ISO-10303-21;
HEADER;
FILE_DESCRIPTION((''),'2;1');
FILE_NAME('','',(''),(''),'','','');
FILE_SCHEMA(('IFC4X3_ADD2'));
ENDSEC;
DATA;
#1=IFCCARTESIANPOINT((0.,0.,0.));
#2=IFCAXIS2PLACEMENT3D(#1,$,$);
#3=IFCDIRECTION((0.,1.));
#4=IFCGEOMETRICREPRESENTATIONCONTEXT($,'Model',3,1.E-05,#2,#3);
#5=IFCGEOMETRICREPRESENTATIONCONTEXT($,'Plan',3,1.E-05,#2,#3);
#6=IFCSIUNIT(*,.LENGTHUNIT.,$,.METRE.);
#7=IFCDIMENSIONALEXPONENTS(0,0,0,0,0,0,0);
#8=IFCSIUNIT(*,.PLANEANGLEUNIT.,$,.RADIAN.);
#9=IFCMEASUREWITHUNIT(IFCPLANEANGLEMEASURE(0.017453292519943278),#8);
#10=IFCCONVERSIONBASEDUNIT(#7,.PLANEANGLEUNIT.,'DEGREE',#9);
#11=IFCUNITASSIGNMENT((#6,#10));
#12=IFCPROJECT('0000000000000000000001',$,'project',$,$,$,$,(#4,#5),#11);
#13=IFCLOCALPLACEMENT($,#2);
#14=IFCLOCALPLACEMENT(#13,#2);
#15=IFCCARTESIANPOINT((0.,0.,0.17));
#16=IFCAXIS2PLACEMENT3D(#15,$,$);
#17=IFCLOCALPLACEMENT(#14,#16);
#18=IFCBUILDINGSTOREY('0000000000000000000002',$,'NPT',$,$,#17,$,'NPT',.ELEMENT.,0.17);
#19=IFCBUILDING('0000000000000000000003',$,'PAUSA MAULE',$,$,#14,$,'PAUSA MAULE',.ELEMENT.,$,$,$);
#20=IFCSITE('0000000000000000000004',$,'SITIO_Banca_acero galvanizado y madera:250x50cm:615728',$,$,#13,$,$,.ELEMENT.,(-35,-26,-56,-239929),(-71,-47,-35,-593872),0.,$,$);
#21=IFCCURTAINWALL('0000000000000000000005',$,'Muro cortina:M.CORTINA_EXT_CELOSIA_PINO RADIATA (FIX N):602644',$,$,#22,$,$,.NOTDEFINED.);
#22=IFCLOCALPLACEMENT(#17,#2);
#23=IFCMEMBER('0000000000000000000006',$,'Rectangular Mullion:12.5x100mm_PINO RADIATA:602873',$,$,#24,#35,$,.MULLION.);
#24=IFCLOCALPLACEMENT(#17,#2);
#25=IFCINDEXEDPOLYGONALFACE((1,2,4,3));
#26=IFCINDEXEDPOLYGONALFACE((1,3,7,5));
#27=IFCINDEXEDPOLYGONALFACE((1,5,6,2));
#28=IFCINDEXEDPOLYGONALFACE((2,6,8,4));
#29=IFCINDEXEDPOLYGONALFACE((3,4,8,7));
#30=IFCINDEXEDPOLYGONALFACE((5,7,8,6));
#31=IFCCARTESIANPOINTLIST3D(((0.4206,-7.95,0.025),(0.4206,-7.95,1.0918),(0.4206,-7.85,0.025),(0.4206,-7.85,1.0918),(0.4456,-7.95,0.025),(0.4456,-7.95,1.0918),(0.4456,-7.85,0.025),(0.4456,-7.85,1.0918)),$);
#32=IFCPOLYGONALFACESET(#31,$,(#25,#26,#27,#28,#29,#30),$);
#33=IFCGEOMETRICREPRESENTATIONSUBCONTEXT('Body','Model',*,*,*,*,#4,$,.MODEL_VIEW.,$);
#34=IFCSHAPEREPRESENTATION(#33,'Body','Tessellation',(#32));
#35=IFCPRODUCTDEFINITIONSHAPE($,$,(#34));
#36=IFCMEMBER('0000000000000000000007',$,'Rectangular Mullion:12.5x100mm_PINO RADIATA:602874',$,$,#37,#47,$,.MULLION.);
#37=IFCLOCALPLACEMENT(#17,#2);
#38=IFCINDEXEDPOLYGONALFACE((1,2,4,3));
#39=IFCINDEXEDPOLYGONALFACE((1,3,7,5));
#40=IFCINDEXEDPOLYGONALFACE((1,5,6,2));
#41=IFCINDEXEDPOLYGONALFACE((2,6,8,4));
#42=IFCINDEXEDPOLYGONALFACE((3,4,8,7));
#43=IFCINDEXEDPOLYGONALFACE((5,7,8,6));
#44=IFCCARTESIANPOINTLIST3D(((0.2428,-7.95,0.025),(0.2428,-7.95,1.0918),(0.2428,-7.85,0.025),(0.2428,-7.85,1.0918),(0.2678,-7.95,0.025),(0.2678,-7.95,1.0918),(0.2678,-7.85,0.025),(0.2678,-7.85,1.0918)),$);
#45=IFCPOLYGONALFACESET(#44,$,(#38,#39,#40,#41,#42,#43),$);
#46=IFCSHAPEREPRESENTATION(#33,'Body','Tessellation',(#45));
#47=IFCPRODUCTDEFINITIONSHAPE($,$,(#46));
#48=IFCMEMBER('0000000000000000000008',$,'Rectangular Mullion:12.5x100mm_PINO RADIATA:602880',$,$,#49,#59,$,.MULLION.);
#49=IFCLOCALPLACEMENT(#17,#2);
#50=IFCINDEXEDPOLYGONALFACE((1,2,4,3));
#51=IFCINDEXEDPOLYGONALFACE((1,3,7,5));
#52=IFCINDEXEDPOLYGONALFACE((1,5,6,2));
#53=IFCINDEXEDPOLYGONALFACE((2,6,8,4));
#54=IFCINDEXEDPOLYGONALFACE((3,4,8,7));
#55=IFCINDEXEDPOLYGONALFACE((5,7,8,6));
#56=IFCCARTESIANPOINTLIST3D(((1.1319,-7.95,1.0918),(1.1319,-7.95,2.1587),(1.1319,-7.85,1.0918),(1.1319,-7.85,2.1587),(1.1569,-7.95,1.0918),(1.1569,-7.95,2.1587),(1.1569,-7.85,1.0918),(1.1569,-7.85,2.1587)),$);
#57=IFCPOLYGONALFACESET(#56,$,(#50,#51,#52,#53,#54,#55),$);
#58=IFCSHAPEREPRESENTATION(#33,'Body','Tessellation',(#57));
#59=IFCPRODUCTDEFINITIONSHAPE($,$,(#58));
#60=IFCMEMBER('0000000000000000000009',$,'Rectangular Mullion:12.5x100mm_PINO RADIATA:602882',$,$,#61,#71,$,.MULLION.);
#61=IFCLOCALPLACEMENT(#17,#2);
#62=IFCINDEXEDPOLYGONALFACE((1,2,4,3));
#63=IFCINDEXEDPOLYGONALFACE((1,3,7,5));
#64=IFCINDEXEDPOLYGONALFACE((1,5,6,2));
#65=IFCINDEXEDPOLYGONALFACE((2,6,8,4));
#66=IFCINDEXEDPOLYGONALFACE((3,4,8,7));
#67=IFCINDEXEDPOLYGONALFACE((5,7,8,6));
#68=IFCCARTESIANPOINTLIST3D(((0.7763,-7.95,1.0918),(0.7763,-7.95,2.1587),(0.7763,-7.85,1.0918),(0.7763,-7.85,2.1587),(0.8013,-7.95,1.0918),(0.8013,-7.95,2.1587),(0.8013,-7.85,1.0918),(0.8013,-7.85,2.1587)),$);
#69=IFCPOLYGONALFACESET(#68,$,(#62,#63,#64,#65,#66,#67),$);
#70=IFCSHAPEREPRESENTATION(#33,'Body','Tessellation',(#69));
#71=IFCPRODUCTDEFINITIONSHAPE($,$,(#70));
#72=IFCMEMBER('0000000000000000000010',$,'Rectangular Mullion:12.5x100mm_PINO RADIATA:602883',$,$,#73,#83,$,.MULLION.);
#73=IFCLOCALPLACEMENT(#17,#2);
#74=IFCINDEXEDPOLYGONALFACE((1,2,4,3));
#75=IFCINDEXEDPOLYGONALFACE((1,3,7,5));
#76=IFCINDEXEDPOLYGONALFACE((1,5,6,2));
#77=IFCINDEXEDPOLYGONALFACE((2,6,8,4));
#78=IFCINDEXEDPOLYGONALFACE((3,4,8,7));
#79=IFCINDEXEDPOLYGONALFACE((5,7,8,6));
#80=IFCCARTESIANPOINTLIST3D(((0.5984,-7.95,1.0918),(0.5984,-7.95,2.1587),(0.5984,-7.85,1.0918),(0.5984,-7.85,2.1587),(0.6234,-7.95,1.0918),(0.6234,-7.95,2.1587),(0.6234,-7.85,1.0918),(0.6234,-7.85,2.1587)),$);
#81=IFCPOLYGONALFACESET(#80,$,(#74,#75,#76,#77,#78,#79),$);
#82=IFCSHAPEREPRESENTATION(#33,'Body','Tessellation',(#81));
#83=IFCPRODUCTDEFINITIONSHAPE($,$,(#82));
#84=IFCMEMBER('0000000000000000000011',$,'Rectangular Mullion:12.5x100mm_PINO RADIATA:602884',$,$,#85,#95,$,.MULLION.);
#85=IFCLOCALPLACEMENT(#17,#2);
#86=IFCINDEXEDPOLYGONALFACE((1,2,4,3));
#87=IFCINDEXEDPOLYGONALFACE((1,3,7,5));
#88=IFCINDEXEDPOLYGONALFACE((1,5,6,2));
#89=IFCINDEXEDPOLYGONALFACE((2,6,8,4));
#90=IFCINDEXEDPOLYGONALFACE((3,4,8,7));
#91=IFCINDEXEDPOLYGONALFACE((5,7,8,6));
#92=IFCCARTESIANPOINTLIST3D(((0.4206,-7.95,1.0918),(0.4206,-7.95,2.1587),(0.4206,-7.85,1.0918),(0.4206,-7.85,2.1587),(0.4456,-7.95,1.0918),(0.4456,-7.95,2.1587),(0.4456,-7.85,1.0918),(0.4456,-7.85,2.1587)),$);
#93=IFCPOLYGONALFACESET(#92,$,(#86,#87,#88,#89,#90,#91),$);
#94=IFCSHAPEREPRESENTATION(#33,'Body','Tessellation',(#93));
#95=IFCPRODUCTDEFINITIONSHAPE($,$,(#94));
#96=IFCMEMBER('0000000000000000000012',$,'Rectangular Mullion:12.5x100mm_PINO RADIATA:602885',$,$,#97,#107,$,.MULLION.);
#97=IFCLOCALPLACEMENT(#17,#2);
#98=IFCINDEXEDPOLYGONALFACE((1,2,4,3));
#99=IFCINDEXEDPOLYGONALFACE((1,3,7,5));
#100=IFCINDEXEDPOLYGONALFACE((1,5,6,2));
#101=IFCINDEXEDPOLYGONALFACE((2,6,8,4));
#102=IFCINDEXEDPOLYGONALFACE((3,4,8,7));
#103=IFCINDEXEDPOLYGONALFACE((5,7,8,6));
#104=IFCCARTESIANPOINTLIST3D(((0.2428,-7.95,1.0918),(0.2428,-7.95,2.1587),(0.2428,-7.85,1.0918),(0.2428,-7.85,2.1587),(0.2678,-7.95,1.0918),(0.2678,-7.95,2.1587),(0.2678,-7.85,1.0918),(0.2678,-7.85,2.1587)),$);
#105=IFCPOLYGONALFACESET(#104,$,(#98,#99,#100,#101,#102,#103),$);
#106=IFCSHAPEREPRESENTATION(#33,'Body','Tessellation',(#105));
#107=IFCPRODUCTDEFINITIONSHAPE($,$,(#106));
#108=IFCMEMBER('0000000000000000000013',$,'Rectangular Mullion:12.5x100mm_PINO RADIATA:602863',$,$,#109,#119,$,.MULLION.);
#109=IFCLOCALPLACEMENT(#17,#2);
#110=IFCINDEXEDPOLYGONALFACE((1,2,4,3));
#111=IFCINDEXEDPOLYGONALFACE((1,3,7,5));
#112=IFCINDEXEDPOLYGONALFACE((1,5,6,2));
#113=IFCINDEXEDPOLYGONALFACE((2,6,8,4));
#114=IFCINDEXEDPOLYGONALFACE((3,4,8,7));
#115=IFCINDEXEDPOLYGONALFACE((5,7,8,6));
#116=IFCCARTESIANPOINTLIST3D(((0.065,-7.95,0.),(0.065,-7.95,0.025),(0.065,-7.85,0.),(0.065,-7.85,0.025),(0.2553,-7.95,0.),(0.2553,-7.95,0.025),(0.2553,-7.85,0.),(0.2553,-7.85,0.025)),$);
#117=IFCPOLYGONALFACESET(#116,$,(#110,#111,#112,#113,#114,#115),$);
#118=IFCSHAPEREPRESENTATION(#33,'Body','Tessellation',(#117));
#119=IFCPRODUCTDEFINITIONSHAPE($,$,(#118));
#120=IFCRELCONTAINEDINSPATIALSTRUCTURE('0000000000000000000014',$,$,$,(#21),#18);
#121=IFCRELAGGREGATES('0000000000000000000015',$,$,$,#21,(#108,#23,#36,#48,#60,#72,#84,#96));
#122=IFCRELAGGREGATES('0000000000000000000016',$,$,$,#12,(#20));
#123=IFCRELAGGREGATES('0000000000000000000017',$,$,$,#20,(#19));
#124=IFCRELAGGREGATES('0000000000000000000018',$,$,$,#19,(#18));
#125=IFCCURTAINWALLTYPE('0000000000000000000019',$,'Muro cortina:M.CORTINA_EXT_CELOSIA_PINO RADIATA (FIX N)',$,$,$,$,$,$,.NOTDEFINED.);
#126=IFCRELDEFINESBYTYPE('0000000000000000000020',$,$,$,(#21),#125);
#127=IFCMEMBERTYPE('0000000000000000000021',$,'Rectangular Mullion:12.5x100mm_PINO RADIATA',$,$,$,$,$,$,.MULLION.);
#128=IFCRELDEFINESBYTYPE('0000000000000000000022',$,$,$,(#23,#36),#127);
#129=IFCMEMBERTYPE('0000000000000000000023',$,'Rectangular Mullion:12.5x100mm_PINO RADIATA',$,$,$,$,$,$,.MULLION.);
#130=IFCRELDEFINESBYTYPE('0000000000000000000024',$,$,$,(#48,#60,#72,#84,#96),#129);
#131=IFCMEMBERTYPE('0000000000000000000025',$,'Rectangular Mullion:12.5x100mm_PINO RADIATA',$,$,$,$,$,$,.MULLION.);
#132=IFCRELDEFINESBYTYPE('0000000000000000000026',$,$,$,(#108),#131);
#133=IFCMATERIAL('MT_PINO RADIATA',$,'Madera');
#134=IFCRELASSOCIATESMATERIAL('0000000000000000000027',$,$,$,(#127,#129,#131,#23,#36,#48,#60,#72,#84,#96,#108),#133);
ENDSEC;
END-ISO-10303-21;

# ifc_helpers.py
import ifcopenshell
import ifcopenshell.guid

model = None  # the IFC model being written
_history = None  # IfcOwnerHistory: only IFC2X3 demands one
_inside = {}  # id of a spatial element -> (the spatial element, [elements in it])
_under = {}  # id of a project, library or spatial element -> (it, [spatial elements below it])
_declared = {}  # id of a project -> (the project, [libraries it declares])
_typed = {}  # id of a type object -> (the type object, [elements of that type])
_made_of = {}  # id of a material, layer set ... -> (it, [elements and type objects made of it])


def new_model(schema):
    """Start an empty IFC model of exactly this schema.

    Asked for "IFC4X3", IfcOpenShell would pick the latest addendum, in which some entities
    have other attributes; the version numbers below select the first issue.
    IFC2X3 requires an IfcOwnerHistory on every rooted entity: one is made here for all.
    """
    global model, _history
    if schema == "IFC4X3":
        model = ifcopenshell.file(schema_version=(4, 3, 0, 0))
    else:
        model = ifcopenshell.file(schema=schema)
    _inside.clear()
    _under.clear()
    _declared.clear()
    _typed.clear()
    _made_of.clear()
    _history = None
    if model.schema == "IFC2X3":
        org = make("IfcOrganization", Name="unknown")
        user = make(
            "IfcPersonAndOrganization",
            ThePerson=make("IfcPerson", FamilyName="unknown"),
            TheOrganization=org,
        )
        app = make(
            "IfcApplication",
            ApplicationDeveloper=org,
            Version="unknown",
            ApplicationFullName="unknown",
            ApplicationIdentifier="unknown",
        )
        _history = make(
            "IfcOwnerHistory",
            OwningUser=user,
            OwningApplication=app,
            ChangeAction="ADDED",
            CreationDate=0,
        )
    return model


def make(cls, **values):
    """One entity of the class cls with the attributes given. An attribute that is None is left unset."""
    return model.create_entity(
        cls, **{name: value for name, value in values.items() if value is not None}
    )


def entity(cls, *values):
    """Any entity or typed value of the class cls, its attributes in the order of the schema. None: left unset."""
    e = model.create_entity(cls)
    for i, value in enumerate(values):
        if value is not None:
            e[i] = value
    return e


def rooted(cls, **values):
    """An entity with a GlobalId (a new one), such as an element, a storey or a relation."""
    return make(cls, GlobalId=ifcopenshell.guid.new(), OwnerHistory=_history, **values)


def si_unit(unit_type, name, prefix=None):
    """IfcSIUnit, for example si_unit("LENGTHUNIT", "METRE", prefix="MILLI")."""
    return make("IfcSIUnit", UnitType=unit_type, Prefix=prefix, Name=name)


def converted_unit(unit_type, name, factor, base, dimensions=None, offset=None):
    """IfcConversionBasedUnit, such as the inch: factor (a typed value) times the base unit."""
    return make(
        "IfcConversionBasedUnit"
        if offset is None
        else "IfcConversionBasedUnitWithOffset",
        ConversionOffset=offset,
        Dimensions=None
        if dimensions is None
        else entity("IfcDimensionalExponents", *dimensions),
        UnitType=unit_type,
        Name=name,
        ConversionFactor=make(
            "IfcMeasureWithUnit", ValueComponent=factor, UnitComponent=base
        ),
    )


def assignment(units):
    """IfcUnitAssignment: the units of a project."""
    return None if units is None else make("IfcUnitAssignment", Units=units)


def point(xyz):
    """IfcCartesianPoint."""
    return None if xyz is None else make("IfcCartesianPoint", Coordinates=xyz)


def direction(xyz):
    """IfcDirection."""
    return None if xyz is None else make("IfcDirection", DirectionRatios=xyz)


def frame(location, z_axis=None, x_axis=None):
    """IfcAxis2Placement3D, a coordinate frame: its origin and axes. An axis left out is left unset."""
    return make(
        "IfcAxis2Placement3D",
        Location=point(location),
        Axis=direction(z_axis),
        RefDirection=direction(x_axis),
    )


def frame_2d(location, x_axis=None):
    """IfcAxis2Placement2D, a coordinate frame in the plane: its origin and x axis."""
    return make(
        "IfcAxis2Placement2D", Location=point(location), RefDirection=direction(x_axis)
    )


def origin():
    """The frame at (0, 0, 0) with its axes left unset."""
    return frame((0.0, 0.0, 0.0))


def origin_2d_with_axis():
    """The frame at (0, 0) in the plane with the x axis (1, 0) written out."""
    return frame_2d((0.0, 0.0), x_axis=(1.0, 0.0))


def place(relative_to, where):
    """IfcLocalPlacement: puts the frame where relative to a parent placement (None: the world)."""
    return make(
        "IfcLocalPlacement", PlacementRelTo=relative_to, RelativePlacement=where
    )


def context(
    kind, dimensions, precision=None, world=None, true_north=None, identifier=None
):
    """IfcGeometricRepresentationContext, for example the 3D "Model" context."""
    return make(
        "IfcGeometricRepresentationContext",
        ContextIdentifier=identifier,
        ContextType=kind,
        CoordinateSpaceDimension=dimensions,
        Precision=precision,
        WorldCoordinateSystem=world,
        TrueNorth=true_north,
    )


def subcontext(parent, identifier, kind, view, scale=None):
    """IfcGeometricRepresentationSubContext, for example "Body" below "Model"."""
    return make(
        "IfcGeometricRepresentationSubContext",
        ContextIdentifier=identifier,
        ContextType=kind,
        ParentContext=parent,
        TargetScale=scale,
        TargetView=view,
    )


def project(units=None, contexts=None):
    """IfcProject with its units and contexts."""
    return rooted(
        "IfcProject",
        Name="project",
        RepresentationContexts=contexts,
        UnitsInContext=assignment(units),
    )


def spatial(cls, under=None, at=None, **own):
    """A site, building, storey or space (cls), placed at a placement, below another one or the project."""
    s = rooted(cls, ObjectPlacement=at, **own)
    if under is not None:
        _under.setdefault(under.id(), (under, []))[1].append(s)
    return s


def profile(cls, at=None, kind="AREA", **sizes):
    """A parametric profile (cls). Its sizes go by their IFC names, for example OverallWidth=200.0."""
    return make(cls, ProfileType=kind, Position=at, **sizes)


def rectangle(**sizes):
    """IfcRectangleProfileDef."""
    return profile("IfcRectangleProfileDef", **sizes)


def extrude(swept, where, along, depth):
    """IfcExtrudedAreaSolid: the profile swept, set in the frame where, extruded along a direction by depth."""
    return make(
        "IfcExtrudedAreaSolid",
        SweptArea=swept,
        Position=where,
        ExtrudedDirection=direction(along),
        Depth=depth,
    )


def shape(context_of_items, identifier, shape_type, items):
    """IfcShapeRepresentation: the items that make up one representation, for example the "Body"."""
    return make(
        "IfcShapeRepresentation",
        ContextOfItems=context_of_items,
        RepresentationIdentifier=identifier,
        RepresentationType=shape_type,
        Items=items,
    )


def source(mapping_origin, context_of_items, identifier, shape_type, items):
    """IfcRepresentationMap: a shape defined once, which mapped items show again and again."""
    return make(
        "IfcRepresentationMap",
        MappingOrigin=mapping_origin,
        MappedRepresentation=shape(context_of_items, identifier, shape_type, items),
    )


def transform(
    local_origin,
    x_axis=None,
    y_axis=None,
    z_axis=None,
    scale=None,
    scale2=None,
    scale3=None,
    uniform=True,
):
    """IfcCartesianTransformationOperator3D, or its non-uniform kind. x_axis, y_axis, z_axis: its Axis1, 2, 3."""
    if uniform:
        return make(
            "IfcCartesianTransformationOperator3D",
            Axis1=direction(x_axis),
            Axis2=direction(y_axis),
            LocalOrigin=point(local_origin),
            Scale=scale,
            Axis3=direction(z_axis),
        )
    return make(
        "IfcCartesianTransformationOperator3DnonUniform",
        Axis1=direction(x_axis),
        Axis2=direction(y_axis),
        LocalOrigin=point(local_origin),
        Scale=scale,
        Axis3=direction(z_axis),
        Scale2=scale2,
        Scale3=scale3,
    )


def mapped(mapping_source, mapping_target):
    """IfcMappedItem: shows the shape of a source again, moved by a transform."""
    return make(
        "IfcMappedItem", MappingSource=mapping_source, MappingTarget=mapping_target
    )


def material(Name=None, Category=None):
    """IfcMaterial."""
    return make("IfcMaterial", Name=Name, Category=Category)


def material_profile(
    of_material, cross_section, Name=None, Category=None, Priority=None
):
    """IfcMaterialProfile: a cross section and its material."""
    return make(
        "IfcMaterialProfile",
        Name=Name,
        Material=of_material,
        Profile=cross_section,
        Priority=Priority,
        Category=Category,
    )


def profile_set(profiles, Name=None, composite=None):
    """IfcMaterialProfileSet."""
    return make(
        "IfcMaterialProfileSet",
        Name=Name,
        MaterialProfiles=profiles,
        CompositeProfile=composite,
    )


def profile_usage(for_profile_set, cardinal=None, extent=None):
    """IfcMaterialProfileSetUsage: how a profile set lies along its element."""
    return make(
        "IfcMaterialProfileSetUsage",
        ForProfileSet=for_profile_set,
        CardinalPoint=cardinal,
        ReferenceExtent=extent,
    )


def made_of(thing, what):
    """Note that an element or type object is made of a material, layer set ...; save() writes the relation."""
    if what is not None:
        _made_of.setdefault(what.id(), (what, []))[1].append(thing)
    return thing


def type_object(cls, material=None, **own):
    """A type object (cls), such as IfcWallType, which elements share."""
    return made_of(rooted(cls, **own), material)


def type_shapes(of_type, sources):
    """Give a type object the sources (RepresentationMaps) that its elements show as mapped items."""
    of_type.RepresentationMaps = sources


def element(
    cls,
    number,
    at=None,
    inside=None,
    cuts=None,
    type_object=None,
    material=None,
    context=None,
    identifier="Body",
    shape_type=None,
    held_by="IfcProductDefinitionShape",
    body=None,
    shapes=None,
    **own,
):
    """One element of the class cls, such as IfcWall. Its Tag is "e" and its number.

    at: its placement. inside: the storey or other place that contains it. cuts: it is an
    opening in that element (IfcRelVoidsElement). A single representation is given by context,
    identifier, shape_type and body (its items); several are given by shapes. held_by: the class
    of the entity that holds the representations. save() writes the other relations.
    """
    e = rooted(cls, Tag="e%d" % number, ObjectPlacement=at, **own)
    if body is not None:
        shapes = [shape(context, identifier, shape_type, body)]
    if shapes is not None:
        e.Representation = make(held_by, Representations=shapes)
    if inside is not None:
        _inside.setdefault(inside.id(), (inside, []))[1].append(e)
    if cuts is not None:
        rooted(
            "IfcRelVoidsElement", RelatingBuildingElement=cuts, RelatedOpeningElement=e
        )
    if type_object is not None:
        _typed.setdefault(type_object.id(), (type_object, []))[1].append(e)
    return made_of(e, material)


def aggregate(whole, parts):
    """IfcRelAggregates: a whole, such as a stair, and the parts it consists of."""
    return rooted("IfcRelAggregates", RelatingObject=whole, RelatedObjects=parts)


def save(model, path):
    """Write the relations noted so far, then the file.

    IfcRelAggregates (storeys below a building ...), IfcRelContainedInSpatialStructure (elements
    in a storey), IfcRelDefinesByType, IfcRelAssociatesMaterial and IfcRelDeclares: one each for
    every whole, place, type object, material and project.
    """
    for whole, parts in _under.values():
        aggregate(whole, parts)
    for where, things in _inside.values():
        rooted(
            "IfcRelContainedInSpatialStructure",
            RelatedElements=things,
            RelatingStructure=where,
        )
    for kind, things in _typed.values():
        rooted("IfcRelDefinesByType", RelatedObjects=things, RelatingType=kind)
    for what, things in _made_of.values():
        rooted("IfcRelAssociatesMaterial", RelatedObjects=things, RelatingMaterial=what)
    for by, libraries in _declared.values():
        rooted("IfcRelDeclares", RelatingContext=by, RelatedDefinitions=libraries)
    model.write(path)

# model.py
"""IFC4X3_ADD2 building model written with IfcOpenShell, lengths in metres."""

from ifc_helpers import new_model, entity, si_unit, converted_unit, direction, frame, frame_2d, origin, origin_2d_with_axis, place, context, subcontext, project, spatial, rectangle, extrude, source, transform, mapped, material, material_profile, profile_set, profile_usage, type_object, type_shapes, element, aggregate, save


model = new_model("IFC4X3_ADD2")

# Units and contexts
model_context = context("Model", 3, precision=1e-05, world=origin(), true_north=direction((0.0, 1.0)))
plan_context = context("Plan", 3, precision=1e-05, world=origin(), true_north=direction((0.0, 1.0)))
body_context = subcontext(model_context, "Body", "Model", "MODEL_VIEW")
ifc_project = project(units=[si_unit("LENGTHUNIT", "METRE"), converted_unit("PLANEANGLEUNIT", "DEGREE", entity("IfcPlaneAngleMeasure", 0.017453292519943278), si_unit("PLANEANGLEUNIT", "RADIAN"), dimensions=[0, 0, 0, 0, 0, 0, 0])], contexts=[model_context, plan_context])

# Site, building, storey
site_placement = place(None, origin())
site = spatial("IfcSite", under=ifc_project, at=site_placement, Name="SITIO_Banca_acero galvanizado y madera:250x50cm:615728", CompositionType="ELEMENT", RefLatitude=(-35, -26, -56, -239929), RefLongitude=(-71, -47, -35, -593872), RefElevation=0.0)
building_placement = place(site_placement, origin())
building = spatial("IfcBuilding", under=site, at=building_placement, Name="PAUSA MAULE", LongName="PAUSA MAULE", CompositionType="ELEMENT")
storey_placement = place(building_placement, frame((0.0, 0.0, 0.17)))
storey = spatial("IfcBuildingStorey", under=building, at=storey_placement, Name="NPT", LongName="NPT", CompositionType="ELEMENT", Elevation=0.17)

# Curtain wall, members
curtain_wall_type = type_object("IfcCurtainWallType", Name="Muro cortina:M.CORTINA_EXT_CELOSIA_PINO RADIATA (FIX N)", PredefinedType="NOTDEFINED")
curtain_wall_placement = place(storey_placement, frame((0.0, 0.0, -0.17)))
curtain_wall = element("IfcCurtainWall", 1, at=curtain_wall_placement, inside=storey, type_object=curtain_wall_type, Name="Muro cortina:M.CORTINA_EXT_CELOSIA_PINO RADIATA (FIX N):602644", PredefinedType="NOTDEFINED")
ifc_material_1 = material(Name="MT_PINO RADIATA", Category="Madera")
ifc_material_profile = material_profile(ifc_material_1, rectangle(XDim=0.025, YDim=0.1, at=frame_2d((0.0, 0.0), x_axis=(1.0, 0.0))), Name="12.5x100mm_PINO RADIATA")
ifc_profile_set = profile_set([ifc_material_profile], Name="12.5x100mm_PINO RADIATA")
ifc_profile_usage = profile_usage(ifc_profile_set)
member_type_1 = type_object("IfcMemberType", Name="Rectangular Mullion:12.5x100mm_PINO RADIATA", PredefinedType="MULLION", material=ifc_profile_set)
shared_shape_1 = source(origin(), body_context, "Body", "SweptSolid", [
    extrude(rectangle(XDim=0.025, YDim=0.1, at=origin_2d_with_axis()), frame((0.0, 0.0, -1.0668), z_axis=(0.0, 0.0, 1.0), x_axis=(-1.0, 0.0, 0.0)), (0.0, 0.0, 1.0), 1.0668),
])
type_shapes(member_type_1, [shared_shape_1])
member_1_placement = place(curtain_wall_placement, frame((0.4331, -7.9, 0.195), z_axis=(0.0, 0.0, -1.0), x_axis=(-1.0, 0.0, 0.0)))
member_1 = element("IfcMember", 2, at=member_1_placement, type_object=member_type_1, material=ifc_profile_usage, Name="Rectangular Mullion:12.5x100mm_PINO RADIATA:602873", PredefinedType="MULLION", context=body_context, shape_type="MappedRepresentation", body=[
    mapped(shared_shape_1, transform((0.0, 0.0, 0.0), scale=1.0)),
])
member_2_placement = place(curtain_wall_placement, frame((0.2553, -7.9, 0.195), z_axis=(0.0, 0.0, -1.0), x_axis=(-1.0, 0.0, 0.0)))
member_2 = element("IfcMember", 3, at=member_2_placement, type_object=member_type_1, material=ifc_profile_usage, Name="Rectangular Mullion:12.5x100mm_PINO RADIATA:602874", PredefinedType="MULLION", context=body_context, shape_type="MappedRepresentation", body=[
    mapped(shared_shape_1, transform((0.0, 0.0, 0.0), scale=1.0)),
])
member_type_2 = type_object("IfcMemberType", Name="Rectangular Mullion:12.5x100mm_PINO RADIATA", PredefinedType="MULLION", material=ifc_profile_set)
shared_shape_2 = source(origin(), body_context, "Body", "SweptSolid", [
    extrude(rectangle(XDim=0.025, YDim=0.1, at=origin_2d_with_axis()), frame((0.0, 0.0, -1.0668), z_axis=(0.0, 0.0, 1.0), x_axis=(-1.0, 0.0, 0.0)), (0.0, 0.0, 1.0), 1.0668),
])
type_shapes(member_type_2, [shared_shape_2])
member_3_placement = place(curtain_wall_placement, frame((1.1444, -7.9, 1.2618), z_axis=(0.0, 0.0, -1.0), x_axis=(-1.0, 0.0, 0.0)))
member_3 = element("IfcMember", 4, at=member_3_placement, type_object=member_type_2, material=ifc_profile_usage, Name="Rectangular Mullion:12.5x100mm_PINO RADIATA:602880", PredefinedType="MULLION", context=body_context, shape_type="MappedRepresentation", body=[
    mapped(shared_shape_2, transform((0.0, 0.0, 0.0), scale=1.0)),
])
member_4_placement = place(curtain_wall_placement, frame((0.7888, -7.9, 1.2618), z_axis=(0.0, 0.0, -1.0), x_axis=(-1.0, 0.0, 0.0)))
member_4 = element("IfcMember", 5, at=member_4_placement, type_object=member_type_2, material=ifc_profile_usage, Name="Rectangular Mullion:12.5x100mm_PINO RADIATA:602882", PredefinedType="MULLION", context=body_context, shape_type="MappedRepresentation", body=[
    mapped(shared_shape_2, transform((0.0, 0.0, 0.0), scale=1.0)),
])
member_5_placement = place(curtain_wall_placement, frame((0.6109, -7.9, 1.2618), z_axis=(0.0, 0.0, -1.0), x_axis=(-1.0, 0.0, 0.0)))
member_5 = element("IfcMember", 6, at=member_5_placement, type_object=member_type_2, material=ifc_profile_usage, Name="Rectangular Mullion:12.5x100mm_PINO RADIATA:602883", PredefinedType="MULLION", context=body_context, shape_type="MappedRepresentation", body=[
    mapped(shared_shape_2, transform((0.0, 0.0, 0.0), scale=1.0)),
])
member_6_placement = place(curtain_wall_placement, frame((0.4331, -7.9, 1.2618), z_axis=(0.0, 0.0, -1.0), x_axis=(-1.0, 0.0, 0.0)))
member_6 = element("IfcMember", 7, at=member_6_placement, type_object=member_type_2, material=ifc_profile_usage, Name="Rectangular Mullion:12.5x100mm_PINO RADIATA:602884", PredefinedType="MULLION", context=body_context, shape_type="MappedRepresentation", body=[
    mapped(shared_shape_2, transform((0.0, 0.0, 0.0), scale=1.0)),
])
member_7_placement = place(curtain_wall_placement, frame((0.2553, -7.9, 1.2618), z_axis=(0.0, 0.0, -1.0), x_axis=(-1.0, 0.0, 0.0)))
member_7 = element("IfcMember", 8, at=member_7_placement, type_object=member_type_2, material=ifc_profile_usage, Name="Rectangular Mullion:12.5x100mm_PINO RADIATA:602885", PredefinedType="MULLION", context=body_context, shape_type="MappedRepresentation", body=[
    mapped(shared_shape_2, transform((0.0, 0.0, 0.0), scale=1.0)),
])
member_type_3 = type_object("IfcMemberType", Name="Rectangular Mullion:12.5x100mm_PINO RADIATA", PredefinedType="MULLION", material=ifc_profile_set)
shared_shape_3 = source(origin(), body_context, "Body", "SweptSolid", [
    extrude(rectangle(XDim=0.025, YDim=0.1, at=frame_2d((0.0, 0.0), x_axis=(1.0, 0.0))), frame((-0.0125, 0.0, -0.1903), z_axis=(0.0, 0.0, 1.0), x_axis=(-1.0, 0.0, 0.0)), (0.0, 0.0, 1.0), 0.1903),
])
type_shapes(member_type_3, [shared_shape_3])
member_8_placement = place(curtain_wall_placement, frame((0.2553, -7.9, 0.17), z_axis=(1.0, 0.0, 0.0), x_axis=(0.0, 0.0, -1.0)))
member_8 = element("IfcMember", 9, at=member_8_placement, type_object=member_type_3, material=ifc_profile_usage, Name="Rectangular Mullion:12.5x100mm_PINO RADIATA:602863", PredefinedType="MULLION", context=body_context, shape_type="MappedRepresentation", body=[
    mapped(shared_shape_3, transform((0.0, 0.0, 0.0), scale=1.0)),
])
aggregate(curtain_wall, [member_8, member_1, member_2, member_3, member_4, member_5, member_6, member_7])

save(model, "model.ifc")
